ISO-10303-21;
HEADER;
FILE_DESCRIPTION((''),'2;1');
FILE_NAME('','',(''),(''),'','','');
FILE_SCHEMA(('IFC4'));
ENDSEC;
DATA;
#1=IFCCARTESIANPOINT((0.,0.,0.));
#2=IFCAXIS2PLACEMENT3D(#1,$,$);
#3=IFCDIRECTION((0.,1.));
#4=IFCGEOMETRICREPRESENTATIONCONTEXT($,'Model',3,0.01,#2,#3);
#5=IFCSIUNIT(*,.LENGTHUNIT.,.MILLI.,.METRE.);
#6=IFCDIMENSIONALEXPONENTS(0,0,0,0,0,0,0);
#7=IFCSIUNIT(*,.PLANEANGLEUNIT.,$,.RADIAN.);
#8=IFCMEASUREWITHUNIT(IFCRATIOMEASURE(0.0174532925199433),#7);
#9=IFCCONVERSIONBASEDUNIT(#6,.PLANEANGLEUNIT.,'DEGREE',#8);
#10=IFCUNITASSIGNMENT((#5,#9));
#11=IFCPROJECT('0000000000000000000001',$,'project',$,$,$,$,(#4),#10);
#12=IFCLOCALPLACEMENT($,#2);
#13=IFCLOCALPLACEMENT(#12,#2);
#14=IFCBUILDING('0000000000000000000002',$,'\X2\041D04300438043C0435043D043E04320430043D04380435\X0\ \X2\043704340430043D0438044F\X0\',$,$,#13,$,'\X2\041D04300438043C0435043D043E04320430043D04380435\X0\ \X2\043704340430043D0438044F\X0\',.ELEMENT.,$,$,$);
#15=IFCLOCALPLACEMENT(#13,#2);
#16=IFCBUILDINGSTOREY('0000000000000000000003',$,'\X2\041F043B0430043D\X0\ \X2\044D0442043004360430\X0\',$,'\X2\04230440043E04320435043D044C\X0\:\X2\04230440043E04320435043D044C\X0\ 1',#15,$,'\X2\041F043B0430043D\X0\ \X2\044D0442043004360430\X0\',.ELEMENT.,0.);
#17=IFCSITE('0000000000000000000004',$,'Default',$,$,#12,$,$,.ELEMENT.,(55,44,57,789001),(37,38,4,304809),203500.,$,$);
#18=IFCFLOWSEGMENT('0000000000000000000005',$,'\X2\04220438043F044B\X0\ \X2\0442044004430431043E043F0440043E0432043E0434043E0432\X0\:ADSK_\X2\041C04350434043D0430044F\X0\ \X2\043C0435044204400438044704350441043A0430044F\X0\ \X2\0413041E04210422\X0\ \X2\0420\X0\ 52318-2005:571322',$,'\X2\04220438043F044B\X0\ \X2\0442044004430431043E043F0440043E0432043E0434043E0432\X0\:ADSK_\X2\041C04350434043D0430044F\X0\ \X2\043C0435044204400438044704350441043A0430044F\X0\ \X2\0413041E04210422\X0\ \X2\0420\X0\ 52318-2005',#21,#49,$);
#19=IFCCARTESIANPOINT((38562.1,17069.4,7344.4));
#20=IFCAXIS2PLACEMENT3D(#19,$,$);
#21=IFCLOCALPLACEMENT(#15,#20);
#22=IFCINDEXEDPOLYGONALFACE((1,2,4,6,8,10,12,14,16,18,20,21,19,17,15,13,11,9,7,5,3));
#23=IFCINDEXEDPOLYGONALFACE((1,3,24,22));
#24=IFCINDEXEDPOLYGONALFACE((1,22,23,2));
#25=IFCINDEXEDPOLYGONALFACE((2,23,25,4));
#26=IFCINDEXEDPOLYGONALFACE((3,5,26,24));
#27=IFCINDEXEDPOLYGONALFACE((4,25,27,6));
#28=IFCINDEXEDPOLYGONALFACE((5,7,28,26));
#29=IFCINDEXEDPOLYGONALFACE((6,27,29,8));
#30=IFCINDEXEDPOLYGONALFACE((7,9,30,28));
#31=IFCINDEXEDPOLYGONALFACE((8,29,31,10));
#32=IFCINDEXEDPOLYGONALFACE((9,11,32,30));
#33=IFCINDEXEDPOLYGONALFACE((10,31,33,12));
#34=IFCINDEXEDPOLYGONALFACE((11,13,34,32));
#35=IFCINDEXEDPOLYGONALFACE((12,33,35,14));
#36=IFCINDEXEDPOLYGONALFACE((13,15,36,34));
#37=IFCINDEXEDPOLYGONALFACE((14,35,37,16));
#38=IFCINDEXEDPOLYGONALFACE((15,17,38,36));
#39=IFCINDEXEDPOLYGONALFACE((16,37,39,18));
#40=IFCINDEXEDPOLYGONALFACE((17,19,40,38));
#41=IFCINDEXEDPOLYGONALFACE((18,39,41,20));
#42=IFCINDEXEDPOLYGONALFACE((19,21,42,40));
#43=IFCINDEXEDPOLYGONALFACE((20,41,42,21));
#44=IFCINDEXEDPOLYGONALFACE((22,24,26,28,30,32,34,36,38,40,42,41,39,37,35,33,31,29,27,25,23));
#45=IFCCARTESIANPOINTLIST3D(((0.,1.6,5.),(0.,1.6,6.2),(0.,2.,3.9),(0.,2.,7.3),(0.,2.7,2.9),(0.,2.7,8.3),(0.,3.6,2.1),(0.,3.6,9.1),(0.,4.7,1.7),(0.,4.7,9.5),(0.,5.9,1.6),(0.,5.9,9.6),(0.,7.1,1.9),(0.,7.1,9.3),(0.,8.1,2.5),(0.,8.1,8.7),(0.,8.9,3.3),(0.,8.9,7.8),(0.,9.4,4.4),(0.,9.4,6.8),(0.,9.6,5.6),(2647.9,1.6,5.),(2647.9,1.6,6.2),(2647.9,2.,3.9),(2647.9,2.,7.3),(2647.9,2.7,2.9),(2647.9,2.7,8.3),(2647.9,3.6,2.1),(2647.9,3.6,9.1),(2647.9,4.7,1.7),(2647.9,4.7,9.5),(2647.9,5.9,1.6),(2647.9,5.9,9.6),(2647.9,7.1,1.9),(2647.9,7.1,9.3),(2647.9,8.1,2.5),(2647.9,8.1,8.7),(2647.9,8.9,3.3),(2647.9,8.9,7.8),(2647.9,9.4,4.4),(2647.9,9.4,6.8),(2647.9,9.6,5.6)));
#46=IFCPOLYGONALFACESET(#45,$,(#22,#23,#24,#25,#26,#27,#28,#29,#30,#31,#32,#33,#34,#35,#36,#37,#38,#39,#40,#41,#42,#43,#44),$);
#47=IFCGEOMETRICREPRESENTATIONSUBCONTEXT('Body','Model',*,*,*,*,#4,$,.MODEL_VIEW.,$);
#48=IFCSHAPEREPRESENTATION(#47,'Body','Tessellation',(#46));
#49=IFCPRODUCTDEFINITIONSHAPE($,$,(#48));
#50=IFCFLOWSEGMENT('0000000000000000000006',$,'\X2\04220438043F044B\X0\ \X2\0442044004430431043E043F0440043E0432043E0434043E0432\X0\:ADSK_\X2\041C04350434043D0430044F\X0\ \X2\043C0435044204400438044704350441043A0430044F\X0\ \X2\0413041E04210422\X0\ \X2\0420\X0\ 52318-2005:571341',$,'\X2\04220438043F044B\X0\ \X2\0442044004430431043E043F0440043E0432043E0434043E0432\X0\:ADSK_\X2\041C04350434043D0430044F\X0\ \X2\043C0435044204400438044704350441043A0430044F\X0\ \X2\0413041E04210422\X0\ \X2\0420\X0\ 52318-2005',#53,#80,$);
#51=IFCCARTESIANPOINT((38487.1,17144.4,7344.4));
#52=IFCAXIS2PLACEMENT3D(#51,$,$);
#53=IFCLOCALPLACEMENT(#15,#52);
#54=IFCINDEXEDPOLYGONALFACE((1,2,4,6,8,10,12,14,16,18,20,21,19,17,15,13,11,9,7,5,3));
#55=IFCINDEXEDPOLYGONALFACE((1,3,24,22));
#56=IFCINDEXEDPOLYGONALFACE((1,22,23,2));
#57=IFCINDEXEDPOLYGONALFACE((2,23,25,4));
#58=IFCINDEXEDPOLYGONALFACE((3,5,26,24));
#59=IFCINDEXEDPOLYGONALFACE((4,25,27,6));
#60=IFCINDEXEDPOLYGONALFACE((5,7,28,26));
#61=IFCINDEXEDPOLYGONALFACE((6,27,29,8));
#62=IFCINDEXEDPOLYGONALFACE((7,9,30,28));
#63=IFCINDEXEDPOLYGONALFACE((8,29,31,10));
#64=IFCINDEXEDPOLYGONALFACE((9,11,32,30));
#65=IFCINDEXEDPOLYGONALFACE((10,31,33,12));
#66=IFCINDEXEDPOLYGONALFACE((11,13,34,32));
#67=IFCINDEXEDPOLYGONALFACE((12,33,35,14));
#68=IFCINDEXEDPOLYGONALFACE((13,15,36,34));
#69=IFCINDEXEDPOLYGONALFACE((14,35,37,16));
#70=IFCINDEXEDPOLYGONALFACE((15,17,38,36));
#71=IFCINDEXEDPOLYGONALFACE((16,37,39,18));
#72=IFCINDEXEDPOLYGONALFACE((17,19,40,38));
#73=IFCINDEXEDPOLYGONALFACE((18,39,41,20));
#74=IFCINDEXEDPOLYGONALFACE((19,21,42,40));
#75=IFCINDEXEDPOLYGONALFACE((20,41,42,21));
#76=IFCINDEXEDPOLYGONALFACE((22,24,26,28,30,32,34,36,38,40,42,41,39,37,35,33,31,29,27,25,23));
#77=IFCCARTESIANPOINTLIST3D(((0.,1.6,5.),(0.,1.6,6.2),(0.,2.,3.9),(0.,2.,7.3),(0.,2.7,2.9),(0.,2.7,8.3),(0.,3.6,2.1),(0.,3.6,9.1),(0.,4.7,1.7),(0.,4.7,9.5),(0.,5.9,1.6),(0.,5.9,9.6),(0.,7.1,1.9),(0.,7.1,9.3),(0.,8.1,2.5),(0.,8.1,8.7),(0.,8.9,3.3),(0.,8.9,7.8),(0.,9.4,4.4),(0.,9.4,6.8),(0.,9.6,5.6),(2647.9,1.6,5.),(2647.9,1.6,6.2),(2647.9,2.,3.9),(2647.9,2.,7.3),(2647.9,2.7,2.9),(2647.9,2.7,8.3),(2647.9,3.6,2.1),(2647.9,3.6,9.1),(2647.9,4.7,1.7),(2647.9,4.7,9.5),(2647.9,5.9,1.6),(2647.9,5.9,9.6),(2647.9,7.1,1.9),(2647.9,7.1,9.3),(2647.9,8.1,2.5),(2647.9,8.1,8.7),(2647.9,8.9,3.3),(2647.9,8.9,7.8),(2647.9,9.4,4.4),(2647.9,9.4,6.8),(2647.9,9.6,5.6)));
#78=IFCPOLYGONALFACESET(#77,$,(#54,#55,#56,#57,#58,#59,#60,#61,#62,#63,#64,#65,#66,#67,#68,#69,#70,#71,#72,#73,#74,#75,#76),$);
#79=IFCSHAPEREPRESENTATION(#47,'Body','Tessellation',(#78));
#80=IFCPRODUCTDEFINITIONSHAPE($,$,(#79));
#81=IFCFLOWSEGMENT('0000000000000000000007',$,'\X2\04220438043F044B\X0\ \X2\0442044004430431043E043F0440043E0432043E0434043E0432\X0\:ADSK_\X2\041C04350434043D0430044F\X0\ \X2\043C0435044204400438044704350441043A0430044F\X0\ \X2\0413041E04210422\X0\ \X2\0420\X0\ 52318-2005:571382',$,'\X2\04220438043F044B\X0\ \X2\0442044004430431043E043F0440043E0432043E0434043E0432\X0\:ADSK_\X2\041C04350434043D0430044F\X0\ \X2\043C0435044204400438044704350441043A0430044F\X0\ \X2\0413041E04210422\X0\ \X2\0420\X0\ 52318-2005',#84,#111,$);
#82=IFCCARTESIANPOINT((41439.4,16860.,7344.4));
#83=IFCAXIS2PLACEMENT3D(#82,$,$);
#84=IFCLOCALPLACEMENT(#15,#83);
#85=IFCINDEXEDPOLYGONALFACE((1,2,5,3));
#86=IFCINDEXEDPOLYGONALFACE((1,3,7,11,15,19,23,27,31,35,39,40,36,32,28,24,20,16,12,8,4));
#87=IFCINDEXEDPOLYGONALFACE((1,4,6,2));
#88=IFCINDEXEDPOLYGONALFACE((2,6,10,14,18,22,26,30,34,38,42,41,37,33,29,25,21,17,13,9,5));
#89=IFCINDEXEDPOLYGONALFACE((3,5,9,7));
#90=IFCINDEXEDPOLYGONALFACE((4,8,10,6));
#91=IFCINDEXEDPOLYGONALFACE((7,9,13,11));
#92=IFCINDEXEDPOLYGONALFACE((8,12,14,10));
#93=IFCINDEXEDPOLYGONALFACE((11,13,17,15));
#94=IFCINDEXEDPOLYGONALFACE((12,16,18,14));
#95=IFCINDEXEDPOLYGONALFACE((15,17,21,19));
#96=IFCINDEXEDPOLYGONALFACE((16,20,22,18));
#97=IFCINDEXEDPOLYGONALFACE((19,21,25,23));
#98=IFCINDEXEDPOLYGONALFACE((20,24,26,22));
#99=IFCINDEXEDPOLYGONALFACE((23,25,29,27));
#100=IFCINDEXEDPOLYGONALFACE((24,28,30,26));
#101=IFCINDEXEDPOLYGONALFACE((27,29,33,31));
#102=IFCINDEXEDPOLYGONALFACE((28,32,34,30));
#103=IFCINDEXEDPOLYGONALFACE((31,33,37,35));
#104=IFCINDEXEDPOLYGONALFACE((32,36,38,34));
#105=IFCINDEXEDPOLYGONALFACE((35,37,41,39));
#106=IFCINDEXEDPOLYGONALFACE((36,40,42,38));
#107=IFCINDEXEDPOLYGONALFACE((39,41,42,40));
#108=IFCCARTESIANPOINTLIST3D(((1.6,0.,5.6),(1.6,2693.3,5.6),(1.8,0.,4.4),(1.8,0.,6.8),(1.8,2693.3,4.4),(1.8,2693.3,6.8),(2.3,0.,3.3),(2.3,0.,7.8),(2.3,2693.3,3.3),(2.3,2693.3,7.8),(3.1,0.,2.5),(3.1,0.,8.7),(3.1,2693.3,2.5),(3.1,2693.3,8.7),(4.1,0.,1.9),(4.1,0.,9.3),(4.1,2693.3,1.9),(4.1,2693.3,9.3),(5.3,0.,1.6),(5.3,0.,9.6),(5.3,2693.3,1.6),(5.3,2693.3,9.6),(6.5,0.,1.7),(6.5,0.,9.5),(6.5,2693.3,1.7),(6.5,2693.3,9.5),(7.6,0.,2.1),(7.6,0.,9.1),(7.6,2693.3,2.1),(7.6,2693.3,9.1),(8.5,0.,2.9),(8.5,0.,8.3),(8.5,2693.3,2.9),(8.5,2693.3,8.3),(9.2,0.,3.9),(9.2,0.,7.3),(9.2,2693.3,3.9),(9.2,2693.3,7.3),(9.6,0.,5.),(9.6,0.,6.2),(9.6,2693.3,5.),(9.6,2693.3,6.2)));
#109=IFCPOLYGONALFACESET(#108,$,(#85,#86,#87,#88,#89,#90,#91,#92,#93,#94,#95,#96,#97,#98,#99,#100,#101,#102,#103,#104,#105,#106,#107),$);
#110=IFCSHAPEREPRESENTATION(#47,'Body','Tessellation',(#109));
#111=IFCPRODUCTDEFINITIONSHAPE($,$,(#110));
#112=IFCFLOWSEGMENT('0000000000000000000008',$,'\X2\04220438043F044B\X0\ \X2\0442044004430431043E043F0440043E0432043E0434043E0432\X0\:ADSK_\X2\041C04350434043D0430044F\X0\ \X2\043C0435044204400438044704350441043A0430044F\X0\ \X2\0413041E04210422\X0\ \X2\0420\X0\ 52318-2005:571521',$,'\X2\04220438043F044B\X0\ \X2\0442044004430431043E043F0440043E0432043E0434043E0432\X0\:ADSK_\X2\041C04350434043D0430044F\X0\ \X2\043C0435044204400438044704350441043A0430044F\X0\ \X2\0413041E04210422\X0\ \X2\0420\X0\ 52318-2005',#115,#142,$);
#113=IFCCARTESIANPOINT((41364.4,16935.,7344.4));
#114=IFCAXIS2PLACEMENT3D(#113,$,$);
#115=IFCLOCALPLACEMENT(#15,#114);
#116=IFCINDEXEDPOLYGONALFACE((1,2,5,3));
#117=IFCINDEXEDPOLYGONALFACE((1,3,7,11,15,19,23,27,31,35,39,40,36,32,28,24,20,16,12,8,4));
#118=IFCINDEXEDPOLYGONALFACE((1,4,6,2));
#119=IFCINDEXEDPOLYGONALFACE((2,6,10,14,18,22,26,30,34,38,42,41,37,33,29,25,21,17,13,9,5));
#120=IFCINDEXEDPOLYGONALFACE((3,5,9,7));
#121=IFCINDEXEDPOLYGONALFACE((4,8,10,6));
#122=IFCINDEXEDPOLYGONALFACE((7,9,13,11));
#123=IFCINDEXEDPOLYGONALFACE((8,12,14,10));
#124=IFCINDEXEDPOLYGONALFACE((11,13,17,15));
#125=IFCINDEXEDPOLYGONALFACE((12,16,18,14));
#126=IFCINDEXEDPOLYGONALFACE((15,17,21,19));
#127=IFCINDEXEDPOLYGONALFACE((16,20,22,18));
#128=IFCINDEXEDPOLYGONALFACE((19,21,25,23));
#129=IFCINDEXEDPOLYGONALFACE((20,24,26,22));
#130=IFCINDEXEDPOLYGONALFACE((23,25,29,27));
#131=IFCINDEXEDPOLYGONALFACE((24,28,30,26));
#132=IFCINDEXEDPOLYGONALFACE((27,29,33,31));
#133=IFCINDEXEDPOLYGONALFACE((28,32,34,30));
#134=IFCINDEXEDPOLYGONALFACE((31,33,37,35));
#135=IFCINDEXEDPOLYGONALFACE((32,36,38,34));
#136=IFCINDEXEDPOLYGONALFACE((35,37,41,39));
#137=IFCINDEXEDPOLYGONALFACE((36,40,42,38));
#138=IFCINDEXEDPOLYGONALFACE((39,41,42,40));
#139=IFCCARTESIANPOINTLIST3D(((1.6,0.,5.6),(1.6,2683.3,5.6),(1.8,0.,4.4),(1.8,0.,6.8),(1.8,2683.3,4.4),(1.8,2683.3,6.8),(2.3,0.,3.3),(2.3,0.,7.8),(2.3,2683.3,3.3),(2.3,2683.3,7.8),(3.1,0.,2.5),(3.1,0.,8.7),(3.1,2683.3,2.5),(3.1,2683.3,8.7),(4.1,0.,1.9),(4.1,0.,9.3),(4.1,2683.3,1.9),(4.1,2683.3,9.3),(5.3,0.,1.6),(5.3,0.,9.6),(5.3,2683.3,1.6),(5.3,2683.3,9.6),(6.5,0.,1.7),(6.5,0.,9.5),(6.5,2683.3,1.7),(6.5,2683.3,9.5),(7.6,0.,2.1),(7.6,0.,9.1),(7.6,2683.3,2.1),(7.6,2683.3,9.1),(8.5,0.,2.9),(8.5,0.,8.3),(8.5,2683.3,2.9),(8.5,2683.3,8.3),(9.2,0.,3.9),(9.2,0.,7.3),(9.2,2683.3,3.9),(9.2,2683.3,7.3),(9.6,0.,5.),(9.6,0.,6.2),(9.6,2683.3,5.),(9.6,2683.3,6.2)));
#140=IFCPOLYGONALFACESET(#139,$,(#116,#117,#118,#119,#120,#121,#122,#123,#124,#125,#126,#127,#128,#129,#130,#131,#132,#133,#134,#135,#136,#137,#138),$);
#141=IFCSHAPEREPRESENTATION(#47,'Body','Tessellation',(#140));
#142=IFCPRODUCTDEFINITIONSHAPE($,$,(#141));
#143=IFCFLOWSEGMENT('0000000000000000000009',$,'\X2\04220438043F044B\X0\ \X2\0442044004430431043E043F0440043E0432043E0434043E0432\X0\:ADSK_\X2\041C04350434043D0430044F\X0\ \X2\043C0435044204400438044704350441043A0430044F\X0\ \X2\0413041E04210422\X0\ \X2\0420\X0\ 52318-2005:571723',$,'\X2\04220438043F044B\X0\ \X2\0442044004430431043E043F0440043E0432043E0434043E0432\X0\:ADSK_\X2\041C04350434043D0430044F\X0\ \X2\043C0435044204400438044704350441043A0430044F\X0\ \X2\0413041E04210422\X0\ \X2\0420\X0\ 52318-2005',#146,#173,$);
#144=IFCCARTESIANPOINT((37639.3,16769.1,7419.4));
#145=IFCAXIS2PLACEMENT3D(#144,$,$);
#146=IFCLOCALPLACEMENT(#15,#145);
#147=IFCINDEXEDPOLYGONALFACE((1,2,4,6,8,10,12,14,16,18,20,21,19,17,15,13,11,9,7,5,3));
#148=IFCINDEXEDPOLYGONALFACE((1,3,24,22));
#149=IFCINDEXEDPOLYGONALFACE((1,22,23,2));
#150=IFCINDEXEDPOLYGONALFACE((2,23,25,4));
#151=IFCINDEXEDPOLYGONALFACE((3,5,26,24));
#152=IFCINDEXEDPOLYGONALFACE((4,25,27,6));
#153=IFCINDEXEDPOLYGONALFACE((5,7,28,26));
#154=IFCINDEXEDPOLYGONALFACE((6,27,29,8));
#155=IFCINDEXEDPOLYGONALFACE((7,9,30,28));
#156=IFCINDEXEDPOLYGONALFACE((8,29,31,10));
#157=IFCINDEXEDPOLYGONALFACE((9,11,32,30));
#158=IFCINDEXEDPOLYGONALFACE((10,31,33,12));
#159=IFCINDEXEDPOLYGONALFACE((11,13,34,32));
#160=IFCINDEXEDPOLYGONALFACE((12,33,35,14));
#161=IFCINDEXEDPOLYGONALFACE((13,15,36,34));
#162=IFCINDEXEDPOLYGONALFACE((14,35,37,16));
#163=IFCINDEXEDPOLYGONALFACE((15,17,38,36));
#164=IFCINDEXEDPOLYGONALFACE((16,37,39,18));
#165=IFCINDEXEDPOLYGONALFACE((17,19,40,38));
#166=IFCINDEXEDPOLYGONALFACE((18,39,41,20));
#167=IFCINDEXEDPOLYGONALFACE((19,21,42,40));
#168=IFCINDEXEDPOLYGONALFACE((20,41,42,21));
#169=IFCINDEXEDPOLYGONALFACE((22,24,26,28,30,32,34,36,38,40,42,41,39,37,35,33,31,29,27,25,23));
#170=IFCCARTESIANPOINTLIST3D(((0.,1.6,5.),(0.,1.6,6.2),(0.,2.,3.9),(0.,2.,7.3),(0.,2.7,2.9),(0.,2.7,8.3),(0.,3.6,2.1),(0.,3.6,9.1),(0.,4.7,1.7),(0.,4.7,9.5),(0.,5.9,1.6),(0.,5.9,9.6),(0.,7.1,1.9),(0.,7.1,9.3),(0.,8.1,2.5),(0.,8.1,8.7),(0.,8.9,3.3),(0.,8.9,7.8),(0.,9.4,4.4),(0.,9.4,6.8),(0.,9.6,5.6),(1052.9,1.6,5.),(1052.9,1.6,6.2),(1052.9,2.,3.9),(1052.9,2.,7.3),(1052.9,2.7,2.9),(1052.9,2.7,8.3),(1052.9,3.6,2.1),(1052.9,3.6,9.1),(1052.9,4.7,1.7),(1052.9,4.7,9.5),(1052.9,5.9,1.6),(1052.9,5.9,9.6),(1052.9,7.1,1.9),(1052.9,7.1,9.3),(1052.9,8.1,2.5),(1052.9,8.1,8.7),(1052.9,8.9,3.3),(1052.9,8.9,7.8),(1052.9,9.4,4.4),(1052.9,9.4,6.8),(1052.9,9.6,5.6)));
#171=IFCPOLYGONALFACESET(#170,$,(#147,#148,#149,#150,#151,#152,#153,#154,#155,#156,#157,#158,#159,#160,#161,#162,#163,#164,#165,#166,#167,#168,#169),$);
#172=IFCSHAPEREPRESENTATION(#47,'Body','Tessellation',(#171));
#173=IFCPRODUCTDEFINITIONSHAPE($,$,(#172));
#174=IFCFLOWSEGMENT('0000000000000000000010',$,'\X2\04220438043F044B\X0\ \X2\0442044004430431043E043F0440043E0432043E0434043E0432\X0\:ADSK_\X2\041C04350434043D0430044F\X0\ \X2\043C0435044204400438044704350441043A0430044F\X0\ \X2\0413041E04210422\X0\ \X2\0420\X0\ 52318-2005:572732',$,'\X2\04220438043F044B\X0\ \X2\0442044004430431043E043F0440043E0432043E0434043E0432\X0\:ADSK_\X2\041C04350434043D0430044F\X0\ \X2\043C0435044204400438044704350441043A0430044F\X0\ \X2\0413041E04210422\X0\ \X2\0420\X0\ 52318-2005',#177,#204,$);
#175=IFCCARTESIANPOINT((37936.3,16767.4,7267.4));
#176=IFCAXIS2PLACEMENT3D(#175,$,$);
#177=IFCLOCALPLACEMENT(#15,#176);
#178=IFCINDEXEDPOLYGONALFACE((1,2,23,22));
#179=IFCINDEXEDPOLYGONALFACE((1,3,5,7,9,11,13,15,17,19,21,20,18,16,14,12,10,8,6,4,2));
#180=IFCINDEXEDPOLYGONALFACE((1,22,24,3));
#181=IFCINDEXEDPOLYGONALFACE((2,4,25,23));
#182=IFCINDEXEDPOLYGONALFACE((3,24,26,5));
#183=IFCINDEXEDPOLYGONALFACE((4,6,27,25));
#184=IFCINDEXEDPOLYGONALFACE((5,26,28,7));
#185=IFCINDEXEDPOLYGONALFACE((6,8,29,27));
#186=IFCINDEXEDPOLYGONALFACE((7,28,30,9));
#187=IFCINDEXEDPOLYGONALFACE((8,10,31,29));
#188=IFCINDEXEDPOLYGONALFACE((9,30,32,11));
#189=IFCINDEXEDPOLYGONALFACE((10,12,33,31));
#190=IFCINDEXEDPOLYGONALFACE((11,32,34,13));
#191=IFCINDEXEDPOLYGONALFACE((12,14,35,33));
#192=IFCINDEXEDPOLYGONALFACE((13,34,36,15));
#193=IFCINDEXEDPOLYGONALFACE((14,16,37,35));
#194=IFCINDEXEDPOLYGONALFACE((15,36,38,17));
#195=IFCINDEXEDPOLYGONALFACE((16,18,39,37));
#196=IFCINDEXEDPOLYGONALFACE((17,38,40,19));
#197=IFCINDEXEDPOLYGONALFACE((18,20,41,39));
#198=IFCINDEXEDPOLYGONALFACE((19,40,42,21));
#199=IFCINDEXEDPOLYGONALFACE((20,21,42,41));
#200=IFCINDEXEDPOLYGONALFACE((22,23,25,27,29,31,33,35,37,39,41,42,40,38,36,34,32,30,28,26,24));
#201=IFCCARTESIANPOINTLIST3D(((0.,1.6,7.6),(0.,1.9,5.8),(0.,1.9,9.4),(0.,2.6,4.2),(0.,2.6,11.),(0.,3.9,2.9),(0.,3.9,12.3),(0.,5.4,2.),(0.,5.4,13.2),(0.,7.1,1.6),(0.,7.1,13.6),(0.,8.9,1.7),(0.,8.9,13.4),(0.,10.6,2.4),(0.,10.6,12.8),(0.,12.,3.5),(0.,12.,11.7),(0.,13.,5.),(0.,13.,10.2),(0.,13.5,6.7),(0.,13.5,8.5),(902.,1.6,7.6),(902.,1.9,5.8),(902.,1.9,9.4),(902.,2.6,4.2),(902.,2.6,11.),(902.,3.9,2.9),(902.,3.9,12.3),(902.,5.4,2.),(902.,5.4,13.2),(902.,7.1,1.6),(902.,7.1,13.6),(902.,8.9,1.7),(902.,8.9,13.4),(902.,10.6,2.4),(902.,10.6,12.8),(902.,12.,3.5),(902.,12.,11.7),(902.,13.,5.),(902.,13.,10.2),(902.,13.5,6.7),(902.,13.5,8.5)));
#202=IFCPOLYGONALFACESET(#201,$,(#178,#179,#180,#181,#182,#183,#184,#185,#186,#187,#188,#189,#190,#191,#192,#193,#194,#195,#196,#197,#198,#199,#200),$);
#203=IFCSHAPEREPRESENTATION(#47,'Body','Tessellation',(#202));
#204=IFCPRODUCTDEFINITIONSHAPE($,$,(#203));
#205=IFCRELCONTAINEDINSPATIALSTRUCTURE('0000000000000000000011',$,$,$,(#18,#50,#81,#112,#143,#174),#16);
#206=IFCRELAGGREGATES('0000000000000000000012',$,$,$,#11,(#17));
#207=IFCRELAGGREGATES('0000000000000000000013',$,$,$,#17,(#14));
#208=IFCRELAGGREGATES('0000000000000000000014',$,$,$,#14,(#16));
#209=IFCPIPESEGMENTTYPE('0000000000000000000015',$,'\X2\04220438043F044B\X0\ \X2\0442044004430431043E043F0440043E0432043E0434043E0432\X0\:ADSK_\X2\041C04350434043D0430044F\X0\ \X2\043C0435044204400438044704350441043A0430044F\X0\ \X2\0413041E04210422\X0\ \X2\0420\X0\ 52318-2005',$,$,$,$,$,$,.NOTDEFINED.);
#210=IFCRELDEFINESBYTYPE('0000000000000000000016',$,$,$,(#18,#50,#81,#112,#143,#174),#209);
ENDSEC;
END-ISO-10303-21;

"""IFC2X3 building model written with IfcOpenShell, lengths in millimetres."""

from ifc_helpers import new_model, entity, si_unit, converted_unit, direction, frame, frame_2d, origin, place, context, subcontext, project, spatial, circle, extrude, type_object, element, save


model = new_model("IFC2X3")

# Units and contexts
model_context = context("Model", 3, precision=0.01, world=origin(), true_north=direction((0.0, 1.0)))
body_context = subcontext(model_context, "Body", "Model", "MODEL_VIEW")
ifc_project = project(units=[si_unit("LENGTHUNIT", "METRE", prefix="MILLI"), converted_unit("PLANEANGLEUNIT", "DEGREE", entity("IfcRatioMeasure", 0.0174532925199433), si_unit("PLANEANGLEUNIT", "RADIAN"), dimensions=[0, 0, 0, 0, 0, 0, 0])], contexts=[model_context])

# Site, building, storey
site_placement = place(None, frame((0.0, 0.0, 0.0)))
site = spatial("IfcSite", under=ifc_project, at=site_placement, Name="Default", CompositionType="ELEMENT", RefLatitude=(55, 44, 57, 789001), RefLongitude=(37, 38, 4, 304809), RefElevation=203500.0)
building_placement = place(site_placement, origin())
building = spatial("IfcBuilding", under=site, at=building_placement, Name="Наименование здания", LongName="Наименование здания", CompositionType="ELEMENT")
storey_placement = place(building_placement, origin())
storey = spatial("IfcBuildingStorey", under=building, at=storey_placement, Name="План этажа", ObjectType="Уровень:Уровень 1", LongName="План этажа", CompositionType="ELEMENT", Elevation=0.0)

# Flow segments
pipe_segment_type = type_object("IfcPipeSegmentType", Name="Типы трубопроводов:ADSK_Медная метрическая ГОСТ Р 52318-2005", PredefinedType="NOTDEFINED")
flow_segment_1_placement = place(storey_placement, frame((38562.1, 17069.4, 7344.4)))
element("IfcFlowSegment", 1, at=flow_segment_1_placement, inside=storey, type_object=pipe_segment_type, Name="Типы трубопроводов:ADSK_Медная метрическая ГОСТ Р 52318-2005:571322", ObjectType="Типы трубопроводов:ADSK_Медная метрическая ГОСТ Р 52318-2005", context=body_context, shape_type="SweptSolid", body=[
    extrude(circle(Radius=4.0, at=frame_2d((0.0, 0.0), x_axis=(1.0, 0.0))), frame((0.0, 5.6, 5.6), z_axis=(1.0, 0.0, 0.0), x_axis=(0.0, 1.0, 0.0)), (0.0, 0.0, 1.0), 2647.9),
])
flow_segment_2_placement = place(storey_placement, frame((38487.1, 17144.4, 7344.4)))
element("IfcFlowSegment", 2, at=flow_segment_2_placement, inside=storey, type_object=pipe_segment_type, Name="Типы трубопроводов:ADSK_Медная метрическая ГОСТ Р 52318-2005:571341", ObjectType="Типы трубопроводов:ADSK_Медная метрическая ГОСТ Р 52318-2005", context=body_context, shape_type="SweptSolid", body=[
    extrude(circle(Radius=4.0, at=frame_2d((0.0, 0.0), x_axis=(1.0, 0.0))), frame((0.0, 5.6, 5.6), z_axis=(1.0, 0.0, 0.0), x_axis=(0.0, 1.0, 0.0)), (0.0, 0.0, 1.0), 2647.9),
])
flow_segment_3_placement = place(storey_placement, frame((41439.4, 16860.0, 7344.4)))
element("IfcFlowSegment", 3, at=flow_segment_3_placement, inside=storey, type_object=pipe_segment_type, Name="Типы трубопроводов:ADSK_Медная метрическая ГОСТ Р 52318-2005:571382", ObjectType="Типы трубопроводов:ADSK_Медная метрическая ГОСТ Р 52318-2005", context=body_context, shape_type="SweptSolid", body=[
    extrude(circle(Radius=4.0, at=frame_2d((0.0, 0.0), x_axis=(1.0, 0.0))), frame((5.6, 0.0, 5.6), z_axis=(0.0, 1.0, 0.0), x_axis=(-1.0, 0.0, 0.0)), (0.0, 0.0, 1.0), 2693.3),
])
flow_segment_4_placement = place(storey_placement, frame((41364.4, 16935.0, 7344.4)))
element("IfcFlowSegment", 4, at=flow_segment_4_placement, inside=storey, type_object=pipe_segment_type, Name="Типы трубопроводов:ADSK_Медная метрическая ГОСТ Р 52318-2005:571521", ObjectType="Типы трубопроводов:ADSK_Медная метрическая ГОСТ Р 52318-2005", context=body_context, shape_type="SweptSolid", body=[
    extrude(circle(Radius=4.0, at=frame_2d((0.0, 0.0), x_axis=(1.0, 0.0))), frame((5.6, 0.0, 5.6), z_axis=(0.0, 1.0, 0.0), x_axis=(-1.0, 0.0, 0.0)), (0.0, 0.0, 1.0), 2683.3),
])
flow_segment_5_placement = place(storey_placement, frame((37639.3, 16769.1, 7419.4)))
element("IfcFlowSegment", 5, at=flow_segment_5_placement, inside=storey, type_object=pipe_segment_type, Name="Типы трубопроводов:ADSK_Медная метрическая ГОСТ Р 52318-2005:571723", ObjectType="Типы трубопроводов:ADSK_Медная метрическая ГОСТ Р 52318-2005", context=body_context, shape_type="SweptSolid", body=[
    extrude(circle(Radius=4.0, at=frame_2d((0.0, 0.0), x_axis=(1.0, 0.0))), frame((0.0, 5.6, 5.6), z_axis=(1.0, 0.0, 0.0), x_axis=(0.0, 1.0, 0.0)), (0.0, 0.0, 1.0), 1052.9),
])
flow_segment_6_placement = place(storey_placement, frame((37936.3, 16767.4, 7267.4)))
element("IfcFlowSegment", 6, at=flow_segment_6_placement, inside=storey, type_object=pipe_segment_type, Name="Типы трубопроводов:ADSK_Медная метрическая ГОСТ Р 52318-2005:572732", ObjectType="Типы трубопроводов:ADSK_Медная метрическая ГОСТ Р 52318-2005", context=body_context, shape_type="SweptSolid", body=[
    extrude(circle(Radius=6.0, at=frame_2d((0.0, 0.0), x_axis=(1.0, 0.0))), frame((0.0, 7.6, 7.6), z_axis=(1.0, 0.0, 0.0), x_axis=(0.0, -1.0, 0.0)), (0.0, 0.0, 1.0), 902.0),
])

save(model, "model.ifc")
